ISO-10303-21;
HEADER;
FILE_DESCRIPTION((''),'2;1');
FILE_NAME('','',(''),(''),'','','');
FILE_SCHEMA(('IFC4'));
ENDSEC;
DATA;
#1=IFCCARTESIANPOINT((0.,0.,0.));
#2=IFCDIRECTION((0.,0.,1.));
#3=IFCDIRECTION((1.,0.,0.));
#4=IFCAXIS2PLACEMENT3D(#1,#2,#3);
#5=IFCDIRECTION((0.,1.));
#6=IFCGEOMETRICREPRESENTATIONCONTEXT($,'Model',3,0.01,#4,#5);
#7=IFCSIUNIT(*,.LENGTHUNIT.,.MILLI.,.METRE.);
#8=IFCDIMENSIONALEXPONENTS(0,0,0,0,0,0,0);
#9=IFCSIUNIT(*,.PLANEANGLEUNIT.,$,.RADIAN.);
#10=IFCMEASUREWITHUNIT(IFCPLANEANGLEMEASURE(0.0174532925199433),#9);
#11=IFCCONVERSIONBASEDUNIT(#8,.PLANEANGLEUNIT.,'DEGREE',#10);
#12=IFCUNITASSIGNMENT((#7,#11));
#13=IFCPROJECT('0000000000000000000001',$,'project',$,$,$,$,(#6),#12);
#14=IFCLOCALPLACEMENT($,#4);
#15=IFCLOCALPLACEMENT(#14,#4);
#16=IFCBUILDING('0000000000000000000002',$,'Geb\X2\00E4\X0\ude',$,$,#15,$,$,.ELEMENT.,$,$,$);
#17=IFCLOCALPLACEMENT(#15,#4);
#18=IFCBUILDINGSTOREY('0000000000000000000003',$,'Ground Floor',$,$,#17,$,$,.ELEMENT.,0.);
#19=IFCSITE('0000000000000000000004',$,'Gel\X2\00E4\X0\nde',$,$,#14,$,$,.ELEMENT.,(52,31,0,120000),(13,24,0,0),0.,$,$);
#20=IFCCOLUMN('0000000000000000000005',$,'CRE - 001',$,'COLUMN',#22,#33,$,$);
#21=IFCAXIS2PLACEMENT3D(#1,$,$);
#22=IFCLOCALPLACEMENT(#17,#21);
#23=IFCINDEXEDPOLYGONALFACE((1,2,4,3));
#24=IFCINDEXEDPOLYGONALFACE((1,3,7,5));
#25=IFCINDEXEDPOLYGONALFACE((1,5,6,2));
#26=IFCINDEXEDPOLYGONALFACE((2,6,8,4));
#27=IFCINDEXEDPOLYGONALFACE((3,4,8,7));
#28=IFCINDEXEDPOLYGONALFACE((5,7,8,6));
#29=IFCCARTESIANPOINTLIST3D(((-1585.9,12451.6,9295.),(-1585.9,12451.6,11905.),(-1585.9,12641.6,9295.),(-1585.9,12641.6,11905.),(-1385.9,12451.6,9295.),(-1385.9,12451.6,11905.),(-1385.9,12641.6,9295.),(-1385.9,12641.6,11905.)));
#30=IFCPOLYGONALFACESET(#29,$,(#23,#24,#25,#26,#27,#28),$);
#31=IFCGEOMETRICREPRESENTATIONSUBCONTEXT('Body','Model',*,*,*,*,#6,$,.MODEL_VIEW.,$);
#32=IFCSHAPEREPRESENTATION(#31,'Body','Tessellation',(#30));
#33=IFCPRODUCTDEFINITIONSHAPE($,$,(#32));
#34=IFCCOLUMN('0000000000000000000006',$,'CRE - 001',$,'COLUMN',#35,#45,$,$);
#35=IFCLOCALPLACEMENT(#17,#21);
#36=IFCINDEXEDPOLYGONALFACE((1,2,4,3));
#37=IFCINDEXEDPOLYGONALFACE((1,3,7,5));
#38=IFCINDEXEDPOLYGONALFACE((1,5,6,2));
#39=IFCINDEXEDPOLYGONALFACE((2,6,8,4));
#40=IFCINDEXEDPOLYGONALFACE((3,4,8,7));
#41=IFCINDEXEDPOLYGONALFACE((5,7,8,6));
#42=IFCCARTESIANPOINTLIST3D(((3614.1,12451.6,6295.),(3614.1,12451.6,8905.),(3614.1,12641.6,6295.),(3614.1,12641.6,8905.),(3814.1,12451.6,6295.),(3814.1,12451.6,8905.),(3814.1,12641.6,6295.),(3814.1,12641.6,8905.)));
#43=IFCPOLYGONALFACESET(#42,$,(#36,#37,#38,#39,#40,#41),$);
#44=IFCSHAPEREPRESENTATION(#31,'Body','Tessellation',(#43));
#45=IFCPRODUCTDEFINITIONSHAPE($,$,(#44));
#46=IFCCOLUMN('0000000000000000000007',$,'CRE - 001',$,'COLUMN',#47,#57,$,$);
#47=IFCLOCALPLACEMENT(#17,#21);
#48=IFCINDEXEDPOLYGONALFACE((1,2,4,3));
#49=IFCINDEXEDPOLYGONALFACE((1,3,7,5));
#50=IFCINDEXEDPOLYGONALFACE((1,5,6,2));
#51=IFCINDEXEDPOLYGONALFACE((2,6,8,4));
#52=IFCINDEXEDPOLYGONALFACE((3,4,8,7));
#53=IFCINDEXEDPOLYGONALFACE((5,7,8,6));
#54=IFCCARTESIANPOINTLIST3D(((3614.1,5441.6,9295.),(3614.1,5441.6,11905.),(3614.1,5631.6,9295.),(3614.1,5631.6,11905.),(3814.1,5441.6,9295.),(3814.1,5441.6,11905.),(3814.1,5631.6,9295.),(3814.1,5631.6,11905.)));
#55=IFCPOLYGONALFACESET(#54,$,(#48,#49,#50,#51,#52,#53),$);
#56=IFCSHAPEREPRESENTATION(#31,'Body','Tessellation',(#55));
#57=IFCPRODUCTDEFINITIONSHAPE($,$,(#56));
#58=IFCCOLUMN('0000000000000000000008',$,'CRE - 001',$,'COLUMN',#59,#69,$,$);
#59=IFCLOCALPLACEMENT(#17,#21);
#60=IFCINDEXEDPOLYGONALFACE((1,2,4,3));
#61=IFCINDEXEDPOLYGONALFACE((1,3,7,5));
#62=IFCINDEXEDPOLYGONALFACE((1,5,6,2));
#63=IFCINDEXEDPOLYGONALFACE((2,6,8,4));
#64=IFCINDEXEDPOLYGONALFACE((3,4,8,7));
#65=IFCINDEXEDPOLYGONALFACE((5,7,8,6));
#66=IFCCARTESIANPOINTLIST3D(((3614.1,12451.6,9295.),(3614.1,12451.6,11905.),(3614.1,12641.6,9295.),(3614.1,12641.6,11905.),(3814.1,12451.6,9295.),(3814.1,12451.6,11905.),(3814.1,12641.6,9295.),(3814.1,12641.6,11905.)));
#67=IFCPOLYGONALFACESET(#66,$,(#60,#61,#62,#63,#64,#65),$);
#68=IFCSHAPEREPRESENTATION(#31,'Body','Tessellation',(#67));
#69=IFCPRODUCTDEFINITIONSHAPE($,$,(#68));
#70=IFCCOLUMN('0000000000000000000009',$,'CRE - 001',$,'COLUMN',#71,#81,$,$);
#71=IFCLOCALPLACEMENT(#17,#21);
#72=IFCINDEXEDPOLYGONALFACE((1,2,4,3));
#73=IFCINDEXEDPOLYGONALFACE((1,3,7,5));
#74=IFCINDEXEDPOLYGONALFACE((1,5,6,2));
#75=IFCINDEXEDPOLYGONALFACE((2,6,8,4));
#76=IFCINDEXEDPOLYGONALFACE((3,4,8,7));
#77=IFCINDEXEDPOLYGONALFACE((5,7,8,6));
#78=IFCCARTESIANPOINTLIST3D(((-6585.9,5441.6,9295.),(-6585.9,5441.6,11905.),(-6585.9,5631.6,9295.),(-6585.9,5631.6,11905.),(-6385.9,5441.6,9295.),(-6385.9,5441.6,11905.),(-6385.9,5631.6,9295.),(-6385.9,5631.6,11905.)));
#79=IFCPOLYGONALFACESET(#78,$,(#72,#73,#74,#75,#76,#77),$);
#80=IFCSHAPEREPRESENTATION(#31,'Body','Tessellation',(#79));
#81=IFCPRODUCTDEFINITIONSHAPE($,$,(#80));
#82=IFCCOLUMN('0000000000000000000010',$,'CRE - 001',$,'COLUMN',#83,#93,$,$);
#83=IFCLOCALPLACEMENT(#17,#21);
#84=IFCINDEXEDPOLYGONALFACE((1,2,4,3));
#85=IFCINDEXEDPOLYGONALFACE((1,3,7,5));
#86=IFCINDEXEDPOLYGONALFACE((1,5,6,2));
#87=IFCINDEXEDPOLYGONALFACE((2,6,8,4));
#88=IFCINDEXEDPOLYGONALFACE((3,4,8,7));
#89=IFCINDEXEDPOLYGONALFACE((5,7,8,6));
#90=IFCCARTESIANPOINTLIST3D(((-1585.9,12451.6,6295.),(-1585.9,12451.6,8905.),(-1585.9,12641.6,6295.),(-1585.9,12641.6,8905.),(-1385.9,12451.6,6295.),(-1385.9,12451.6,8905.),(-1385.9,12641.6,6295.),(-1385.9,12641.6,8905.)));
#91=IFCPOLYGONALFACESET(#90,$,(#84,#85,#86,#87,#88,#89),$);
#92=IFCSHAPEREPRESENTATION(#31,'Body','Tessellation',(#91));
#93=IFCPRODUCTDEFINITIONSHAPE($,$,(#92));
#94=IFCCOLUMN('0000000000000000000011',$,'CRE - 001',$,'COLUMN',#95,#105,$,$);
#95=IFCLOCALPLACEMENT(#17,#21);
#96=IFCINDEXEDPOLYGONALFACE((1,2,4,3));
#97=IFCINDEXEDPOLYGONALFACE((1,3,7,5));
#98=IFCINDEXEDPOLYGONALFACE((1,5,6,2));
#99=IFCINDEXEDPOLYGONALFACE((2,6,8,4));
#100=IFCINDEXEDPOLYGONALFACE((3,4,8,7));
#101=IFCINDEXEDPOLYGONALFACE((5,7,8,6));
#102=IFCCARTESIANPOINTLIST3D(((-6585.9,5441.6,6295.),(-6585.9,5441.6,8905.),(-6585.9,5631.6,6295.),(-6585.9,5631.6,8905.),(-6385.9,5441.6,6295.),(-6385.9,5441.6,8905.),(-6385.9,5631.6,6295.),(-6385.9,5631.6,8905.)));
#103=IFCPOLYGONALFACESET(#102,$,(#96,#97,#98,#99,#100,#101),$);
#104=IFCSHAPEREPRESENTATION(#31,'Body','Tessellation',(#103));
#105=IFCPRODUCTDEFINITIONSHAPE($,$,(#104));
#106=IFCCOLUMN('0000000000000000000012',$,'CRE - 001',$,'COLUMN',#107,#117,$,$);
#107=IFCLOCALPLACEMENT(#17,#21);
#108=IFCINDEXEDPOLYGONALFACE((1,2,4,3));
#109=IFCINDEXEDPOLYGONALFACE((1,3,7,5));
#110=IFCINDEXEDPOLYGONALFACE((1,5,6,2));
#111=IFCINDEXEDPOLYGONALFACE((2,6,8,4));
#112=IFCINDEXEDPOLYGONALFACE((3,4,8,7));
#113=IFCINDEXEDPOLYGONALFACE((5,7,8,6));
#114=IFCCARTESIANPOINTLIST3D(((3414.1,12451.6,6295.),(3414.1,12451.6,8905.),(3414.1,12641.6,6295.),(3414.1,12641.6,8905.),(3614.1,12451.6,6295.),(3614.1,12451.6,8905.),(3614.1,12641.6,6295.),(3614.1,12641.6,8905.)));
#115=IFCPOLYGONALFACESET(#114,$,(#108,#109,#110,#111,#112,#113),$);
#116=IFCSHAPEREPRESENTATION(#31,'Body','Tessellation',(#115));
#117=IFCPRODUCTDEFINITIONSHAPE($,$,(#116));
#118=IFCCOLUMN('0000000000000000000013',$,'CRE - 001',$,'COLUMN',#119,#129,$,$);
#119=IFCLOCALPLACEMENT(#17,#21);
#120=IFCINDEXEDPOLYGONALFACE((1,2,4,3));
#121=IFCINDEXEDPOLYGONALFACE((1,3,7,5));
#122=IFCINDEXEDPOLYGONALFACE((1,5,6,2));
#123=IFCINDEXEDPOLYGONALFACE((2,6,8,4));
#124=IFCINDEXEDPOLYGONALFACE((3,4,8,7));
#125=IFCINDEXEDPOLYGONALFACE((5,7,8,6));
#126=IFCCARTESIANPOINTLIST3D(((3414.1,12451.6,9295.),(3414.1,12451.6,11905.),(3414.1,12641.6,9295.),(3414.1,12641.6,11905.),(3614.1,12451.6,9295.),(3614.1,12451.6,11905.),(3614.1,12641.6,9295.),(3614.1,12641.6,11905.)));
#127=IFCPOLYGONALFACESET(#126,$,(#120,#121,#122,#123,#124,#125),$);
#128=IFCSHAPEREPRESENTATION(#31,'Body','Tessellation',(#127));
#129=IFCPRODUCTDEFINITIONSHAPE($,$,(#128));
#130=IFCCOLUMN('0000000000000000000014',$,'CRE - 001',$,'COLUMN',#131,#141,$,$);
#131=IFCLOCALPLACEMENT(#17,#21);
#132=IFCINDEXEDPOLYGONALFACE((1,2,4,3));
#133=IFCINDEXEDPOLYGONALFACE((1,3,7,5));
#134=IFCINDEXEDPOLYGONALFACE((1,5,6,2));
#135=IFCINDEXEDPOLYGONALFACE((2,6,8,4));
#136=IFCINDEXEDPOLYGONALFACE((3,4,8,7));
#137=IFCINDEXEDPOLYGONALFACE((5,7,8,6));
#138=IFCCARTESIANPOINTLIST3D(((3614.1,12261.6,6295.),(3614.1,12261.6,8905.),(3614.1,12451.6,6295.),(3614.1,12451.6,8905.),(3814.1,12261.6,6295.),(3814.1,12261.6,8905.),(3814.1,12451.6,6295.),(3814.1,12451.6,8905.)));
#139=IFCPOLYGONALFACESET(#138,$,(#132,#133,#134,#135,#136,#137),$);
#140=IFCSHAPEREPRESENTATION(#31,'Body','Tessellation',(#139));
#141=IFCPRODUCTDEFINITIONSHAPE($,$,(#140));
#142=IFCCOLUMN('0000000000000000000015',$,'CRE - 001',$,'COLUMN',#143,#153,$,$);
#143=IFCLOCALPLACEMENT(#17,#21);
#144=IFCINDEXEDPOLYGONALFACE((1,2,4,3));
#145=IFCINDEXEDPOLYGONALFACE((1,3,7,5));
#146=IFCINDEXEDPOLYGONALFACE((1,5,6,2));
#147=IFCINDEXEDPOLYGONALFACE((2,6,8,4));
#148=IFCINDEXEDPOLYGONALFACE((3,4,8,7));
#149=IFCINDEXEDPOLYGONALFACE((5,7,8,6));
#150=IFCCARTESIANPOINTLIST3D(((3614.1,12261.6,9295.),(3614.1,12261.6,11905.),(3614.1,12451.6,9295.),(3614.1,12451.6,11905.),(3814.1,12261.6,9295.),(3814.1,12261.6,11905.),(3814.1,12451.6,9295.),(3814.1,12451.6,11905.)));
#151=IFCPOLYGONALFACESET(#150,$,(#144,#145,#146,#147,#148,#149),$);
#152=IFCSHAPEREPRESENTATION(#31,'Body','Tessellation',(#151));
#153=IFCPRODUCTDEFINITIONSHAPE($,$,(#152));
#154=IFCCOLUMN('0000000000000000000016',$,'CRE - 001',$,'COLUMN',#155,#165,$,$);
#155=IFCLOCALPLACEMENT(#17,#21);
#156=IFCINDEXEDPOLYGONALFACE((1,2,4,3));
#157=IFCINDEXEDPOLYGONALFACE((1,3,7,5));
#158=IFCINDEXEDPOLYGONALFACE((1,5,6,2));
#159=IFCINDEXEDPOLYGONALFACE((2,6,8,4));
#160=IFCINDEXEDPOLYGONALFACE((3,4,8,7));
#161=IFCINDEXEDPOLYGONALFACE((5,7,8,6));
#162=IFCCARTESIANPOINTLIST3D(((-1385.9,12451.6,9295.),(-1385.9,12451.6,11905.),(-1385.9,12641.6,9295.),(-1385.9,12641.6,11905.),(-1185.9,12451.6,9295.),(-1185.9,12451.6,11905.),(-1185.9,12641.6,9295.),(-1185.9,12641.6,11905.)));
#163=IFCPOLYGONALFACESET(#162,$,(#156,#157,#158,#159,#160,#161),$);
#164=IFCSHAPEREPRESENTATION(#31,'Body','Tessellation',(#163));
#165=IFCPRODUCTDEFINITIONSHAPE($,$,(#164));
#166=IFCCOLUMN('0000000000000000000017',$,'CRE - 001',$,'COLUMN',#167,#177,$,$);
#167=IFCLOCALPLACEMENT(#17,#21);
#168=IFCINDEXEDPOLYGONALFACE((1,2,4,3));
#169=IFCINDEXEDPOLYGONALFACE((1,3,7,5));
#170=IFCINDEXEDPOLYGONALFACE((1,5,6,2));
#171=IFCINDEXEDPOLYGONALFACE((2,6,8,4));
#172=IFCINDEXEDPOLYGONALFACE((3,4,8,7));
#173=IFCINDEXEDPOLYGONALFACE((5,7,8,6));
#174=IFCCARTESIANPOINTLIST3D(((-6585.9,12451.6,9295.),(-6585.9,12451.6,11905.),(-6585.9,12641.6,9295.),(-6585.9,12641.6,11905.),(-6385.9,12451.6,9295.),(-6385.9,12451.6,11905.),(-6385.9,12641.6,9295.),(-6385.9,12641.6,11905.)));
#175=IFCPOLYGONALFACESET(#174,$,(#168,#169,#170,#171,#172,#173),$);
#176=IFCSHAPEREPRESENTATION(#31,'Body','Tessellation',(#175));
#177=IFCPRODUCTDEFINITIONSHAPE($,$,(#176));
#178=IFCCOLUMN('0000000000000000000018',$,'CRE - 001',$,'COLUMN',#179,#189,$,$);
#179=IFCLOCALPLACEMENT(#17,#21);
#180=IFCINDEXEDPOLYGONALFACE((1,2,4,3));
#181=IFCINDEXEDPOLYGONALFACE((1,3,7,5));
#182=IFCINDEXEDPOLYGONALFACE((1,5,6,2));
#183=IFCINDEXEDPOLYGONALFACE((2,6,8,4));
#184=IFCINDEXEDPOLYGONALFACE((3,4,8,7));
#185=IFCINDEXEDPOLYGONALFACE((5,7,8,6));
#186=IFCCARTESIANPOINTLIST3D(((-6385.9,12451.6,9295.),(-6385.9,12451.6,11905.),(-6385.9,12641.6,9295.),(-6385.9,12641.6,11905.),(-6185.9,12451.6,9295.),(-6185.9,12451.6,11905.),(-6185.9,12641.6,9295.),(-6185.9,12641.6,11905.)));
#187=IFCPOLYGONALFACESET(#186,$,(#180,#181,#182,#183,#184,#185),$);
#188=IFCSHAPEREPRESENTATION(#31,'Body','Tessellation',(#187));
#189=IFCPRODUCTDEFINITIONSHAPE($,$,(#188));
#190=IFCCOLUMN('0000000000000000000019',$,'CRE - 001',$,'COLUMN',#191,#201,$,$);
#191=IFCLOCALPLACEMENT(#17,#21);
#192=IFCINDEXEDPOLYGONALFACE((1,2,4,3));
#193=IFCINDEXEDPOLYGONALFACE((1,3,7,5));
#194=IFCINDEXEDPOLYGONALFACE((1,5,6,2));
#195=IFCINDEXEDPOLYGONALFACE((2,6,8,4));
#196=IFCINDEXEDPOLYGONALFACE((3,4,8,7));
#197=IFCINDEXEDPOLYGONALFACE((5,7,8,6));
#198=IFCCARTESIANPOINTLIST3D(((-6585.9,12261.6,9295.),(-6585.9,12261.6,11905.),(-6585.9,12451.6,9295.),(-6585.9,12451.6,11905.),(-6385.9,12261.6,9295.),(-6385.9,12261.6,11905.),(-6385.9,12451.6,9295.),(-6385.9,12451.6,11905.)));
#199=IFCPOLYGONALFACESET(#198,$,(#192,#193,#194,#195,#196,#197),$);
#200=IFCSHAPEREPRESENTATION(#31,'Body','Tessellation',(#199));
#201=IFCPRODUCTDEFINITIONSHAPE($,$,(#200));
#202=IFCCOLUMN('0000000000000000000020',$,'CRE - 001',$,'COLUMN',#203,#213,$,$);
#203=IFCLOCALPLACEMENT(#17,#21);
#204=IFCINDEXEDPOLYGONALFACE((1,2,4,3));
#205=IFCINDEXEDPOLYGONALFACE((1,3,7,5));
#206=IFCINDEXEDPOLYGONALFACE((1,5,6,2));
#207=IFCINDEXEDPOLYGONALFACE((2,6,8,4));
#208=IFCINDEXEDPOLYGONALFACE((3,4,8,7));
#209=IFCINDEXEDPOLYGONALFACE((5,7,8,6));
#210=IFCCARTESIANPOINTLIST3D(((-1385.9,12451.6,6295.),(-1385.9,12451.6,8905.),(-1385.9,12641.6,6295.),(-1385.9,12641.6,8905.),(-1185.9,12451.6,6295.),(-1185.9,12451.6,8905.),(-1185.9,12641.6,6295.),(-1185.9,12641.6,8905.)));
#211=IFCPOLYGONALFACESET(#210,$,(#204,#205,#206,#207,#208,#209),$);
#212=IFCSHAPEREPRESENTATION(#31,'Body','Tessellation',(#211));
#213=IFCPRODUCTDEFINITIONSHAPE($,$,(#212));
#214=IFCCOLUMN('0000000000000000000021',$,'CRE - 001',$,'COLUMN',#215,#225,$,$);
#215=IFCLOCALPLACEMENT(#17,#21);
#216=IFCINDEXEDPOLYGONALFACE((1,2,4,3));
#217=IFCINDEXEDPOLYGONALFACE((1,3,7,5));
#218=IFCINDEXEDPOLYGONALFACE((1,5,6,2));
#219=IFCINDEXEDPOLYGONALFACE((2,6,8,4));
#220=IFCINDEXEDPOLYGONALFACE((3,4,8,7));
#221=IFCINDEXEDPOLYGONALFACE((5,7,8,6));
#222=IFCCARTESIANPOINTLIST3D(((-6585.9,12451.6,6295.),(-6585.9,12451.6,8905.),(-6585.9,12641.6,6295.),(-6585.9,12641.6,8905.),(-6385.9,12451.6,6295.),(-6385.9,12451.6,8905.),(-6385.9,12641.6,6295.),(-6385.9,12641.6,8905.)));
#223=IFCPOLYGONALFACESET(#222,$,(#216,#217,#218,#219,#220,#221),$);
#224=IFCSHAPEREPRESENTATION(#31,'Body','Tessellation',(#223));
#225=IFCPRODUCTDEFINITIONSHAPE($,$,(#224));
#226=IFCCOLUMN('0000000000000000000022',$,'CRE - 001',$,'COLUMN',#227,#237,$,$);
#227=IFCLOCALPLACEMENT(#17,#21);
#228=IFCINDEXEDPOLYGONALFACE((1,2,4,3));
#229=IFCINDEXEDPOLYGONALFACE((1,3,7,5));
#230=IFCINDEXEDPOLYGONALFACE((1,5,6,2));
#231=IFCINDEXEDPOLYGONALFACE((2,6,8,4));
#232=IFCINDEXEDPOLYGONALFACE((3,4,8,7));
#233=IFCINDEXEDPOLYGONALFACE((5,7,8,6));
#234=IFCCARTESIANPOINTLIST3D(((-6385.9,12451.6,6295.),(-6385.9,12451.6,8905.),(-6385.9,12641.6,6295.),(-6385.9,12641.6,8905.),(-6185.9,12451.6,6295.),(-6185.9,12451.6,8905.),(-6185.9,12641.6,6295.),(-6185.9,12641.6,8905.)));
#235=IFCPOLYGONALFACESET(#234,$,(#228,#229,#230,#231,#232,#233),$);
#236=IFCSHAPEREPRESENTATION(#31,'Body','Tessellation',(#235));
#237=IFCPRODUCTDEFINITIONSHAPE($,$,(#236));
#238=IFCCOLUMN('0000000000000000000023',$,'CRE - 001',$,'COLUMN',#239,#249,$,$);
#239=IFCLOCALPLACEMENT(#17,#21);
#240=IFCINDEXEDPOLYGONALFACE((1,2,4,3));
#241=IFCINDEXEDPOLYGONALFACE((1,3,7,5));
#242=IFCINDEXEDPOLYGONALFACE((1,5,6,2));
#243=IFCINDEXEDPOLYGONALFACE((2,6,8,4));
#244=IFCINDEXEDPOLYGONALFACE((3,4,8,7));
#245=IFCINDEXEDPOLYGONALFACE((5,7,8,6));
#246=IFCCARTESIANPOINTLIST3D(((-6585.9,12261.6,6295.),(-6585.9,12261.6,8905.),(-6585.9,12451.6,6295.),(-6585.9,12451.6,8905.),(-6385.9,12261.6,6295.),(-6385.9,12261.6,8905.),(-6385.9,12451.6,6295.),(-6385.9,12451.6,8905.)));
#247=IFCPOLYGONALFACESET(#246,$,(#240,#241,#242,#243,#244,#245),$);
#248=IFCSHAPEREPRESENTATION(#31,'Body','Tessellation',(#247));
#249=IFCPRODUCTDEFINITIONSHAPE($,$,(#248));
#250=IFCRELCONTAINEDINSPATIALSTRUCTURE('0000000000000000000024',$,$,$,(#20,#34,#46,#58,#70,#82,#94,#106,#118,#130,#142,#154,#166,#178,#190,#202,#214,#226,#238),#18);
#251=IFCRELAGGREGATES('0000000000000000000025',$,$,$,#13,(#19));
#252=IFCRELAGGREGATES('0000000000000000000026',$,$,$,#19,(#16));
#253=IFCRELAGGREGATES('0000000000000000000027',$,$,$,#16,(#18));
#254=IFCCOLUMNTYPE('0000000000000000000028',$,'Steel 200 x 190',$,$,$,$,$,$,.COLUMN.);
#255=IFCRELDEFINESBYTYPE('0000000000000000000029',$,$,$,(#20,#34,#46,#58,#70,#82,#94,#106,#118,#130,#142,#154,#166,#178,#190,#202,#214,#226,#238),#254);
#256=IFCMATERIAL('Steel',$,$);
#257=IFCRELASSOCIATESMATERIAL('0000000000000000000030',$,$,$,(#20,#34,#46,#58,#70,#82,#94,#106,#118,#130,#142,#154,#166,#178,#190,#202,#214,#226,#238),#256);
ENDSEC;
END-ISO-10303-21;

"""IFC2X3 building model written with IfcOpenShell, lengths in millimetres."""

from ifc_helpers import new_model, entity, si_unit, converted_unit, direction, frame, origin_with_axes, origin_2d_with_axis, place, context, subcontext, project, spatial, rectangle, extrude, material, type_object, element, save


model = new_model("IFC2X3")

# Units and contexts
model_context = context("Model", 3, precision=0.01, world=origin_with_axes(), true_north=direction((0.0, 1.0)))
body_context = subcontext(model_context, "Body", "Model", "MODEL_VIEW")
ifc_project = project(units=[si_unit("LENGTHUNIT", "METRE", prefix="MILLI"), converted_unit("PLANEANGLEUNIT", "DEGREE", entity("IfcPlaneAngleMeasure", 0.0174532925199433), si_unit("PLANEANGLEUNIT", "RADIAN"), dimensions=[0, 0, 0, 0, 0, 0, 0])], contexts=[model_context])

# Site, building, storey
site_placement = place(None, origin_with_axes())
site = spatial("IfcSite", under=ifc_project, at=site_placement, Name="Gelände", CompositionType="ELEMENT", RefLatitude=(52, 31, 0, 120000), RefLongitude=(13, 24, 0, 0), RefElevation=0.0)
building_placement = place(site_placement, origin_with_axes())
building = spatial("IfcBuilding", under=site, at=building_placement, Name="Gebäude", CompositionType="ELEMENT")
storey_placement = place(building_placement, origin_with_axes())
storey = spatial("IfcBuildingStorey", under=building, at=storey_placement, Name="Ground Floor", CompositionType="ELEMENT", Elevation=0.0)

# Columns
ifc_material_1 = material(Name="Steel")
column_type = type_object("IfcColumnType", Name="Steel 200 x 190", PredefinedType="COLUMN")
for number, where, z_axis, x_axis, name in (
    (1, (-1485.9, 12546.6, 9295.0), (0.0, 0.0, 1.0), (1.0, 0.0, 0.0), "CRE - 001"),
    (2, (3714.1, 12546.6, 6295.0), (0.0, 0.0, 1.0), (1.0, 0.0, 0.0), "CRE - 001"),
    (3, (3714.1, 5536.6, 9295.0), (0.0, 0.0, 1.0), (1.0, 0.0, 0.0), "CRE - 001"),
    (4, (3714.1, 12546.6, 9295.0), (0.0, 0.0, 1.0), (1.0, 0.0, 0.0), "CRE - 001"),
    (5, (-6485.9, 5536.6, 9295.0), (0.0, 0.0, 1.0), (1.0, 0.0, 0.0), "CRE - 001"),
    (6, (-1485.9, 12546.6, 6295.0), (0.0, 0.0, 1.0), (1.0, 0.0, 0.0), "CRE - 001"),
    (7, (-6485.9, 5536.6, 6295.0), (0.0, 0.0, 1.0), (1.0, 0.0, 0.0), "CRE - 001"),
    (8, (3514.1, 12546.6, 6295.0), (0.0, 0.0, 1.0), (1.0, 0.0, 0.0), "CRE - 001"),
    (9, (3514.1, 12546.6, 9295.0), (0.0, 0.0, 1.0), (1.0, 0.0, 0.0), "CRE - 001"),
    (10, (3714.1, 12356.6, 6295.0), (0.0, 0.0, 1.0), (1.0, 0.0, 0.0), "CRE - 001"),
    (11, (3714.1, 12356.6, 9295.0), (0.0, 0.0, 1.0), (1.0, 0.0, 0.0), "CRE - 001"),
    (12, (-1285.9, 12546.6, 9295.0), (0.0, 0.0, 1.0), (1.0, 0.0, 0.0), "CRE - 001"),
    (13, (-6485.9, 12546.6, 9295.0), (0.0, 0.0, 1.0), (1.0, 0.0, 0.0), "CRE - 001"),
    (14, (-6285.9, 12546.6, 9295.0), (0.0, 0.0, 1.0), (1.0, 0.0, 0.0), "CRE - 001"),
    (15, (-6485.9, 12356.6, 9295.0), (0.0, 0.0, 1.0), (1.0, 0.0, 0.0), "CRE - 001"),
    (16, (-1285.9, 12546.6, 6295.0), (0.0, 0.0, 1.0), (1.0, 0.0, 0.0), "CRE - 001"),
    (17, (-6485.9, 12546.6, 6295.0), (0.0, 0.0, 1.0), (1.0, 0.0, 0.0), "CRE - 001"),
    (18, (-6285.9, 12546.6, 6295.0), (0.0, 0.0, 1.0), (1.0, 0.0, 0.0), "CRE - 001"),
    (19, (-6485.9, 12356.6, 6295.0), (0.0, 0.0, 1.0), (1.0, 0.0, 0.0), "CRE - 001"),
):
    element("IfcColumn", number, at=place(storey_placement, frame(where, z_axis=z_axis, x_axis=x_axis)), inside=storey, type_object=column_type, material=ifc_material_1, Name=name, ObjectType="COLUMN", context=body_context, shape_type="SweptSolid", body=[
        extrude(rectangle(XDim=200.0, YDim=190.0, at=origin_2d_with_axis()), origin_with_axes(), (0.0, 0.0, 1.0), 2610.0),
    ])

save(model, "model.ifc")
